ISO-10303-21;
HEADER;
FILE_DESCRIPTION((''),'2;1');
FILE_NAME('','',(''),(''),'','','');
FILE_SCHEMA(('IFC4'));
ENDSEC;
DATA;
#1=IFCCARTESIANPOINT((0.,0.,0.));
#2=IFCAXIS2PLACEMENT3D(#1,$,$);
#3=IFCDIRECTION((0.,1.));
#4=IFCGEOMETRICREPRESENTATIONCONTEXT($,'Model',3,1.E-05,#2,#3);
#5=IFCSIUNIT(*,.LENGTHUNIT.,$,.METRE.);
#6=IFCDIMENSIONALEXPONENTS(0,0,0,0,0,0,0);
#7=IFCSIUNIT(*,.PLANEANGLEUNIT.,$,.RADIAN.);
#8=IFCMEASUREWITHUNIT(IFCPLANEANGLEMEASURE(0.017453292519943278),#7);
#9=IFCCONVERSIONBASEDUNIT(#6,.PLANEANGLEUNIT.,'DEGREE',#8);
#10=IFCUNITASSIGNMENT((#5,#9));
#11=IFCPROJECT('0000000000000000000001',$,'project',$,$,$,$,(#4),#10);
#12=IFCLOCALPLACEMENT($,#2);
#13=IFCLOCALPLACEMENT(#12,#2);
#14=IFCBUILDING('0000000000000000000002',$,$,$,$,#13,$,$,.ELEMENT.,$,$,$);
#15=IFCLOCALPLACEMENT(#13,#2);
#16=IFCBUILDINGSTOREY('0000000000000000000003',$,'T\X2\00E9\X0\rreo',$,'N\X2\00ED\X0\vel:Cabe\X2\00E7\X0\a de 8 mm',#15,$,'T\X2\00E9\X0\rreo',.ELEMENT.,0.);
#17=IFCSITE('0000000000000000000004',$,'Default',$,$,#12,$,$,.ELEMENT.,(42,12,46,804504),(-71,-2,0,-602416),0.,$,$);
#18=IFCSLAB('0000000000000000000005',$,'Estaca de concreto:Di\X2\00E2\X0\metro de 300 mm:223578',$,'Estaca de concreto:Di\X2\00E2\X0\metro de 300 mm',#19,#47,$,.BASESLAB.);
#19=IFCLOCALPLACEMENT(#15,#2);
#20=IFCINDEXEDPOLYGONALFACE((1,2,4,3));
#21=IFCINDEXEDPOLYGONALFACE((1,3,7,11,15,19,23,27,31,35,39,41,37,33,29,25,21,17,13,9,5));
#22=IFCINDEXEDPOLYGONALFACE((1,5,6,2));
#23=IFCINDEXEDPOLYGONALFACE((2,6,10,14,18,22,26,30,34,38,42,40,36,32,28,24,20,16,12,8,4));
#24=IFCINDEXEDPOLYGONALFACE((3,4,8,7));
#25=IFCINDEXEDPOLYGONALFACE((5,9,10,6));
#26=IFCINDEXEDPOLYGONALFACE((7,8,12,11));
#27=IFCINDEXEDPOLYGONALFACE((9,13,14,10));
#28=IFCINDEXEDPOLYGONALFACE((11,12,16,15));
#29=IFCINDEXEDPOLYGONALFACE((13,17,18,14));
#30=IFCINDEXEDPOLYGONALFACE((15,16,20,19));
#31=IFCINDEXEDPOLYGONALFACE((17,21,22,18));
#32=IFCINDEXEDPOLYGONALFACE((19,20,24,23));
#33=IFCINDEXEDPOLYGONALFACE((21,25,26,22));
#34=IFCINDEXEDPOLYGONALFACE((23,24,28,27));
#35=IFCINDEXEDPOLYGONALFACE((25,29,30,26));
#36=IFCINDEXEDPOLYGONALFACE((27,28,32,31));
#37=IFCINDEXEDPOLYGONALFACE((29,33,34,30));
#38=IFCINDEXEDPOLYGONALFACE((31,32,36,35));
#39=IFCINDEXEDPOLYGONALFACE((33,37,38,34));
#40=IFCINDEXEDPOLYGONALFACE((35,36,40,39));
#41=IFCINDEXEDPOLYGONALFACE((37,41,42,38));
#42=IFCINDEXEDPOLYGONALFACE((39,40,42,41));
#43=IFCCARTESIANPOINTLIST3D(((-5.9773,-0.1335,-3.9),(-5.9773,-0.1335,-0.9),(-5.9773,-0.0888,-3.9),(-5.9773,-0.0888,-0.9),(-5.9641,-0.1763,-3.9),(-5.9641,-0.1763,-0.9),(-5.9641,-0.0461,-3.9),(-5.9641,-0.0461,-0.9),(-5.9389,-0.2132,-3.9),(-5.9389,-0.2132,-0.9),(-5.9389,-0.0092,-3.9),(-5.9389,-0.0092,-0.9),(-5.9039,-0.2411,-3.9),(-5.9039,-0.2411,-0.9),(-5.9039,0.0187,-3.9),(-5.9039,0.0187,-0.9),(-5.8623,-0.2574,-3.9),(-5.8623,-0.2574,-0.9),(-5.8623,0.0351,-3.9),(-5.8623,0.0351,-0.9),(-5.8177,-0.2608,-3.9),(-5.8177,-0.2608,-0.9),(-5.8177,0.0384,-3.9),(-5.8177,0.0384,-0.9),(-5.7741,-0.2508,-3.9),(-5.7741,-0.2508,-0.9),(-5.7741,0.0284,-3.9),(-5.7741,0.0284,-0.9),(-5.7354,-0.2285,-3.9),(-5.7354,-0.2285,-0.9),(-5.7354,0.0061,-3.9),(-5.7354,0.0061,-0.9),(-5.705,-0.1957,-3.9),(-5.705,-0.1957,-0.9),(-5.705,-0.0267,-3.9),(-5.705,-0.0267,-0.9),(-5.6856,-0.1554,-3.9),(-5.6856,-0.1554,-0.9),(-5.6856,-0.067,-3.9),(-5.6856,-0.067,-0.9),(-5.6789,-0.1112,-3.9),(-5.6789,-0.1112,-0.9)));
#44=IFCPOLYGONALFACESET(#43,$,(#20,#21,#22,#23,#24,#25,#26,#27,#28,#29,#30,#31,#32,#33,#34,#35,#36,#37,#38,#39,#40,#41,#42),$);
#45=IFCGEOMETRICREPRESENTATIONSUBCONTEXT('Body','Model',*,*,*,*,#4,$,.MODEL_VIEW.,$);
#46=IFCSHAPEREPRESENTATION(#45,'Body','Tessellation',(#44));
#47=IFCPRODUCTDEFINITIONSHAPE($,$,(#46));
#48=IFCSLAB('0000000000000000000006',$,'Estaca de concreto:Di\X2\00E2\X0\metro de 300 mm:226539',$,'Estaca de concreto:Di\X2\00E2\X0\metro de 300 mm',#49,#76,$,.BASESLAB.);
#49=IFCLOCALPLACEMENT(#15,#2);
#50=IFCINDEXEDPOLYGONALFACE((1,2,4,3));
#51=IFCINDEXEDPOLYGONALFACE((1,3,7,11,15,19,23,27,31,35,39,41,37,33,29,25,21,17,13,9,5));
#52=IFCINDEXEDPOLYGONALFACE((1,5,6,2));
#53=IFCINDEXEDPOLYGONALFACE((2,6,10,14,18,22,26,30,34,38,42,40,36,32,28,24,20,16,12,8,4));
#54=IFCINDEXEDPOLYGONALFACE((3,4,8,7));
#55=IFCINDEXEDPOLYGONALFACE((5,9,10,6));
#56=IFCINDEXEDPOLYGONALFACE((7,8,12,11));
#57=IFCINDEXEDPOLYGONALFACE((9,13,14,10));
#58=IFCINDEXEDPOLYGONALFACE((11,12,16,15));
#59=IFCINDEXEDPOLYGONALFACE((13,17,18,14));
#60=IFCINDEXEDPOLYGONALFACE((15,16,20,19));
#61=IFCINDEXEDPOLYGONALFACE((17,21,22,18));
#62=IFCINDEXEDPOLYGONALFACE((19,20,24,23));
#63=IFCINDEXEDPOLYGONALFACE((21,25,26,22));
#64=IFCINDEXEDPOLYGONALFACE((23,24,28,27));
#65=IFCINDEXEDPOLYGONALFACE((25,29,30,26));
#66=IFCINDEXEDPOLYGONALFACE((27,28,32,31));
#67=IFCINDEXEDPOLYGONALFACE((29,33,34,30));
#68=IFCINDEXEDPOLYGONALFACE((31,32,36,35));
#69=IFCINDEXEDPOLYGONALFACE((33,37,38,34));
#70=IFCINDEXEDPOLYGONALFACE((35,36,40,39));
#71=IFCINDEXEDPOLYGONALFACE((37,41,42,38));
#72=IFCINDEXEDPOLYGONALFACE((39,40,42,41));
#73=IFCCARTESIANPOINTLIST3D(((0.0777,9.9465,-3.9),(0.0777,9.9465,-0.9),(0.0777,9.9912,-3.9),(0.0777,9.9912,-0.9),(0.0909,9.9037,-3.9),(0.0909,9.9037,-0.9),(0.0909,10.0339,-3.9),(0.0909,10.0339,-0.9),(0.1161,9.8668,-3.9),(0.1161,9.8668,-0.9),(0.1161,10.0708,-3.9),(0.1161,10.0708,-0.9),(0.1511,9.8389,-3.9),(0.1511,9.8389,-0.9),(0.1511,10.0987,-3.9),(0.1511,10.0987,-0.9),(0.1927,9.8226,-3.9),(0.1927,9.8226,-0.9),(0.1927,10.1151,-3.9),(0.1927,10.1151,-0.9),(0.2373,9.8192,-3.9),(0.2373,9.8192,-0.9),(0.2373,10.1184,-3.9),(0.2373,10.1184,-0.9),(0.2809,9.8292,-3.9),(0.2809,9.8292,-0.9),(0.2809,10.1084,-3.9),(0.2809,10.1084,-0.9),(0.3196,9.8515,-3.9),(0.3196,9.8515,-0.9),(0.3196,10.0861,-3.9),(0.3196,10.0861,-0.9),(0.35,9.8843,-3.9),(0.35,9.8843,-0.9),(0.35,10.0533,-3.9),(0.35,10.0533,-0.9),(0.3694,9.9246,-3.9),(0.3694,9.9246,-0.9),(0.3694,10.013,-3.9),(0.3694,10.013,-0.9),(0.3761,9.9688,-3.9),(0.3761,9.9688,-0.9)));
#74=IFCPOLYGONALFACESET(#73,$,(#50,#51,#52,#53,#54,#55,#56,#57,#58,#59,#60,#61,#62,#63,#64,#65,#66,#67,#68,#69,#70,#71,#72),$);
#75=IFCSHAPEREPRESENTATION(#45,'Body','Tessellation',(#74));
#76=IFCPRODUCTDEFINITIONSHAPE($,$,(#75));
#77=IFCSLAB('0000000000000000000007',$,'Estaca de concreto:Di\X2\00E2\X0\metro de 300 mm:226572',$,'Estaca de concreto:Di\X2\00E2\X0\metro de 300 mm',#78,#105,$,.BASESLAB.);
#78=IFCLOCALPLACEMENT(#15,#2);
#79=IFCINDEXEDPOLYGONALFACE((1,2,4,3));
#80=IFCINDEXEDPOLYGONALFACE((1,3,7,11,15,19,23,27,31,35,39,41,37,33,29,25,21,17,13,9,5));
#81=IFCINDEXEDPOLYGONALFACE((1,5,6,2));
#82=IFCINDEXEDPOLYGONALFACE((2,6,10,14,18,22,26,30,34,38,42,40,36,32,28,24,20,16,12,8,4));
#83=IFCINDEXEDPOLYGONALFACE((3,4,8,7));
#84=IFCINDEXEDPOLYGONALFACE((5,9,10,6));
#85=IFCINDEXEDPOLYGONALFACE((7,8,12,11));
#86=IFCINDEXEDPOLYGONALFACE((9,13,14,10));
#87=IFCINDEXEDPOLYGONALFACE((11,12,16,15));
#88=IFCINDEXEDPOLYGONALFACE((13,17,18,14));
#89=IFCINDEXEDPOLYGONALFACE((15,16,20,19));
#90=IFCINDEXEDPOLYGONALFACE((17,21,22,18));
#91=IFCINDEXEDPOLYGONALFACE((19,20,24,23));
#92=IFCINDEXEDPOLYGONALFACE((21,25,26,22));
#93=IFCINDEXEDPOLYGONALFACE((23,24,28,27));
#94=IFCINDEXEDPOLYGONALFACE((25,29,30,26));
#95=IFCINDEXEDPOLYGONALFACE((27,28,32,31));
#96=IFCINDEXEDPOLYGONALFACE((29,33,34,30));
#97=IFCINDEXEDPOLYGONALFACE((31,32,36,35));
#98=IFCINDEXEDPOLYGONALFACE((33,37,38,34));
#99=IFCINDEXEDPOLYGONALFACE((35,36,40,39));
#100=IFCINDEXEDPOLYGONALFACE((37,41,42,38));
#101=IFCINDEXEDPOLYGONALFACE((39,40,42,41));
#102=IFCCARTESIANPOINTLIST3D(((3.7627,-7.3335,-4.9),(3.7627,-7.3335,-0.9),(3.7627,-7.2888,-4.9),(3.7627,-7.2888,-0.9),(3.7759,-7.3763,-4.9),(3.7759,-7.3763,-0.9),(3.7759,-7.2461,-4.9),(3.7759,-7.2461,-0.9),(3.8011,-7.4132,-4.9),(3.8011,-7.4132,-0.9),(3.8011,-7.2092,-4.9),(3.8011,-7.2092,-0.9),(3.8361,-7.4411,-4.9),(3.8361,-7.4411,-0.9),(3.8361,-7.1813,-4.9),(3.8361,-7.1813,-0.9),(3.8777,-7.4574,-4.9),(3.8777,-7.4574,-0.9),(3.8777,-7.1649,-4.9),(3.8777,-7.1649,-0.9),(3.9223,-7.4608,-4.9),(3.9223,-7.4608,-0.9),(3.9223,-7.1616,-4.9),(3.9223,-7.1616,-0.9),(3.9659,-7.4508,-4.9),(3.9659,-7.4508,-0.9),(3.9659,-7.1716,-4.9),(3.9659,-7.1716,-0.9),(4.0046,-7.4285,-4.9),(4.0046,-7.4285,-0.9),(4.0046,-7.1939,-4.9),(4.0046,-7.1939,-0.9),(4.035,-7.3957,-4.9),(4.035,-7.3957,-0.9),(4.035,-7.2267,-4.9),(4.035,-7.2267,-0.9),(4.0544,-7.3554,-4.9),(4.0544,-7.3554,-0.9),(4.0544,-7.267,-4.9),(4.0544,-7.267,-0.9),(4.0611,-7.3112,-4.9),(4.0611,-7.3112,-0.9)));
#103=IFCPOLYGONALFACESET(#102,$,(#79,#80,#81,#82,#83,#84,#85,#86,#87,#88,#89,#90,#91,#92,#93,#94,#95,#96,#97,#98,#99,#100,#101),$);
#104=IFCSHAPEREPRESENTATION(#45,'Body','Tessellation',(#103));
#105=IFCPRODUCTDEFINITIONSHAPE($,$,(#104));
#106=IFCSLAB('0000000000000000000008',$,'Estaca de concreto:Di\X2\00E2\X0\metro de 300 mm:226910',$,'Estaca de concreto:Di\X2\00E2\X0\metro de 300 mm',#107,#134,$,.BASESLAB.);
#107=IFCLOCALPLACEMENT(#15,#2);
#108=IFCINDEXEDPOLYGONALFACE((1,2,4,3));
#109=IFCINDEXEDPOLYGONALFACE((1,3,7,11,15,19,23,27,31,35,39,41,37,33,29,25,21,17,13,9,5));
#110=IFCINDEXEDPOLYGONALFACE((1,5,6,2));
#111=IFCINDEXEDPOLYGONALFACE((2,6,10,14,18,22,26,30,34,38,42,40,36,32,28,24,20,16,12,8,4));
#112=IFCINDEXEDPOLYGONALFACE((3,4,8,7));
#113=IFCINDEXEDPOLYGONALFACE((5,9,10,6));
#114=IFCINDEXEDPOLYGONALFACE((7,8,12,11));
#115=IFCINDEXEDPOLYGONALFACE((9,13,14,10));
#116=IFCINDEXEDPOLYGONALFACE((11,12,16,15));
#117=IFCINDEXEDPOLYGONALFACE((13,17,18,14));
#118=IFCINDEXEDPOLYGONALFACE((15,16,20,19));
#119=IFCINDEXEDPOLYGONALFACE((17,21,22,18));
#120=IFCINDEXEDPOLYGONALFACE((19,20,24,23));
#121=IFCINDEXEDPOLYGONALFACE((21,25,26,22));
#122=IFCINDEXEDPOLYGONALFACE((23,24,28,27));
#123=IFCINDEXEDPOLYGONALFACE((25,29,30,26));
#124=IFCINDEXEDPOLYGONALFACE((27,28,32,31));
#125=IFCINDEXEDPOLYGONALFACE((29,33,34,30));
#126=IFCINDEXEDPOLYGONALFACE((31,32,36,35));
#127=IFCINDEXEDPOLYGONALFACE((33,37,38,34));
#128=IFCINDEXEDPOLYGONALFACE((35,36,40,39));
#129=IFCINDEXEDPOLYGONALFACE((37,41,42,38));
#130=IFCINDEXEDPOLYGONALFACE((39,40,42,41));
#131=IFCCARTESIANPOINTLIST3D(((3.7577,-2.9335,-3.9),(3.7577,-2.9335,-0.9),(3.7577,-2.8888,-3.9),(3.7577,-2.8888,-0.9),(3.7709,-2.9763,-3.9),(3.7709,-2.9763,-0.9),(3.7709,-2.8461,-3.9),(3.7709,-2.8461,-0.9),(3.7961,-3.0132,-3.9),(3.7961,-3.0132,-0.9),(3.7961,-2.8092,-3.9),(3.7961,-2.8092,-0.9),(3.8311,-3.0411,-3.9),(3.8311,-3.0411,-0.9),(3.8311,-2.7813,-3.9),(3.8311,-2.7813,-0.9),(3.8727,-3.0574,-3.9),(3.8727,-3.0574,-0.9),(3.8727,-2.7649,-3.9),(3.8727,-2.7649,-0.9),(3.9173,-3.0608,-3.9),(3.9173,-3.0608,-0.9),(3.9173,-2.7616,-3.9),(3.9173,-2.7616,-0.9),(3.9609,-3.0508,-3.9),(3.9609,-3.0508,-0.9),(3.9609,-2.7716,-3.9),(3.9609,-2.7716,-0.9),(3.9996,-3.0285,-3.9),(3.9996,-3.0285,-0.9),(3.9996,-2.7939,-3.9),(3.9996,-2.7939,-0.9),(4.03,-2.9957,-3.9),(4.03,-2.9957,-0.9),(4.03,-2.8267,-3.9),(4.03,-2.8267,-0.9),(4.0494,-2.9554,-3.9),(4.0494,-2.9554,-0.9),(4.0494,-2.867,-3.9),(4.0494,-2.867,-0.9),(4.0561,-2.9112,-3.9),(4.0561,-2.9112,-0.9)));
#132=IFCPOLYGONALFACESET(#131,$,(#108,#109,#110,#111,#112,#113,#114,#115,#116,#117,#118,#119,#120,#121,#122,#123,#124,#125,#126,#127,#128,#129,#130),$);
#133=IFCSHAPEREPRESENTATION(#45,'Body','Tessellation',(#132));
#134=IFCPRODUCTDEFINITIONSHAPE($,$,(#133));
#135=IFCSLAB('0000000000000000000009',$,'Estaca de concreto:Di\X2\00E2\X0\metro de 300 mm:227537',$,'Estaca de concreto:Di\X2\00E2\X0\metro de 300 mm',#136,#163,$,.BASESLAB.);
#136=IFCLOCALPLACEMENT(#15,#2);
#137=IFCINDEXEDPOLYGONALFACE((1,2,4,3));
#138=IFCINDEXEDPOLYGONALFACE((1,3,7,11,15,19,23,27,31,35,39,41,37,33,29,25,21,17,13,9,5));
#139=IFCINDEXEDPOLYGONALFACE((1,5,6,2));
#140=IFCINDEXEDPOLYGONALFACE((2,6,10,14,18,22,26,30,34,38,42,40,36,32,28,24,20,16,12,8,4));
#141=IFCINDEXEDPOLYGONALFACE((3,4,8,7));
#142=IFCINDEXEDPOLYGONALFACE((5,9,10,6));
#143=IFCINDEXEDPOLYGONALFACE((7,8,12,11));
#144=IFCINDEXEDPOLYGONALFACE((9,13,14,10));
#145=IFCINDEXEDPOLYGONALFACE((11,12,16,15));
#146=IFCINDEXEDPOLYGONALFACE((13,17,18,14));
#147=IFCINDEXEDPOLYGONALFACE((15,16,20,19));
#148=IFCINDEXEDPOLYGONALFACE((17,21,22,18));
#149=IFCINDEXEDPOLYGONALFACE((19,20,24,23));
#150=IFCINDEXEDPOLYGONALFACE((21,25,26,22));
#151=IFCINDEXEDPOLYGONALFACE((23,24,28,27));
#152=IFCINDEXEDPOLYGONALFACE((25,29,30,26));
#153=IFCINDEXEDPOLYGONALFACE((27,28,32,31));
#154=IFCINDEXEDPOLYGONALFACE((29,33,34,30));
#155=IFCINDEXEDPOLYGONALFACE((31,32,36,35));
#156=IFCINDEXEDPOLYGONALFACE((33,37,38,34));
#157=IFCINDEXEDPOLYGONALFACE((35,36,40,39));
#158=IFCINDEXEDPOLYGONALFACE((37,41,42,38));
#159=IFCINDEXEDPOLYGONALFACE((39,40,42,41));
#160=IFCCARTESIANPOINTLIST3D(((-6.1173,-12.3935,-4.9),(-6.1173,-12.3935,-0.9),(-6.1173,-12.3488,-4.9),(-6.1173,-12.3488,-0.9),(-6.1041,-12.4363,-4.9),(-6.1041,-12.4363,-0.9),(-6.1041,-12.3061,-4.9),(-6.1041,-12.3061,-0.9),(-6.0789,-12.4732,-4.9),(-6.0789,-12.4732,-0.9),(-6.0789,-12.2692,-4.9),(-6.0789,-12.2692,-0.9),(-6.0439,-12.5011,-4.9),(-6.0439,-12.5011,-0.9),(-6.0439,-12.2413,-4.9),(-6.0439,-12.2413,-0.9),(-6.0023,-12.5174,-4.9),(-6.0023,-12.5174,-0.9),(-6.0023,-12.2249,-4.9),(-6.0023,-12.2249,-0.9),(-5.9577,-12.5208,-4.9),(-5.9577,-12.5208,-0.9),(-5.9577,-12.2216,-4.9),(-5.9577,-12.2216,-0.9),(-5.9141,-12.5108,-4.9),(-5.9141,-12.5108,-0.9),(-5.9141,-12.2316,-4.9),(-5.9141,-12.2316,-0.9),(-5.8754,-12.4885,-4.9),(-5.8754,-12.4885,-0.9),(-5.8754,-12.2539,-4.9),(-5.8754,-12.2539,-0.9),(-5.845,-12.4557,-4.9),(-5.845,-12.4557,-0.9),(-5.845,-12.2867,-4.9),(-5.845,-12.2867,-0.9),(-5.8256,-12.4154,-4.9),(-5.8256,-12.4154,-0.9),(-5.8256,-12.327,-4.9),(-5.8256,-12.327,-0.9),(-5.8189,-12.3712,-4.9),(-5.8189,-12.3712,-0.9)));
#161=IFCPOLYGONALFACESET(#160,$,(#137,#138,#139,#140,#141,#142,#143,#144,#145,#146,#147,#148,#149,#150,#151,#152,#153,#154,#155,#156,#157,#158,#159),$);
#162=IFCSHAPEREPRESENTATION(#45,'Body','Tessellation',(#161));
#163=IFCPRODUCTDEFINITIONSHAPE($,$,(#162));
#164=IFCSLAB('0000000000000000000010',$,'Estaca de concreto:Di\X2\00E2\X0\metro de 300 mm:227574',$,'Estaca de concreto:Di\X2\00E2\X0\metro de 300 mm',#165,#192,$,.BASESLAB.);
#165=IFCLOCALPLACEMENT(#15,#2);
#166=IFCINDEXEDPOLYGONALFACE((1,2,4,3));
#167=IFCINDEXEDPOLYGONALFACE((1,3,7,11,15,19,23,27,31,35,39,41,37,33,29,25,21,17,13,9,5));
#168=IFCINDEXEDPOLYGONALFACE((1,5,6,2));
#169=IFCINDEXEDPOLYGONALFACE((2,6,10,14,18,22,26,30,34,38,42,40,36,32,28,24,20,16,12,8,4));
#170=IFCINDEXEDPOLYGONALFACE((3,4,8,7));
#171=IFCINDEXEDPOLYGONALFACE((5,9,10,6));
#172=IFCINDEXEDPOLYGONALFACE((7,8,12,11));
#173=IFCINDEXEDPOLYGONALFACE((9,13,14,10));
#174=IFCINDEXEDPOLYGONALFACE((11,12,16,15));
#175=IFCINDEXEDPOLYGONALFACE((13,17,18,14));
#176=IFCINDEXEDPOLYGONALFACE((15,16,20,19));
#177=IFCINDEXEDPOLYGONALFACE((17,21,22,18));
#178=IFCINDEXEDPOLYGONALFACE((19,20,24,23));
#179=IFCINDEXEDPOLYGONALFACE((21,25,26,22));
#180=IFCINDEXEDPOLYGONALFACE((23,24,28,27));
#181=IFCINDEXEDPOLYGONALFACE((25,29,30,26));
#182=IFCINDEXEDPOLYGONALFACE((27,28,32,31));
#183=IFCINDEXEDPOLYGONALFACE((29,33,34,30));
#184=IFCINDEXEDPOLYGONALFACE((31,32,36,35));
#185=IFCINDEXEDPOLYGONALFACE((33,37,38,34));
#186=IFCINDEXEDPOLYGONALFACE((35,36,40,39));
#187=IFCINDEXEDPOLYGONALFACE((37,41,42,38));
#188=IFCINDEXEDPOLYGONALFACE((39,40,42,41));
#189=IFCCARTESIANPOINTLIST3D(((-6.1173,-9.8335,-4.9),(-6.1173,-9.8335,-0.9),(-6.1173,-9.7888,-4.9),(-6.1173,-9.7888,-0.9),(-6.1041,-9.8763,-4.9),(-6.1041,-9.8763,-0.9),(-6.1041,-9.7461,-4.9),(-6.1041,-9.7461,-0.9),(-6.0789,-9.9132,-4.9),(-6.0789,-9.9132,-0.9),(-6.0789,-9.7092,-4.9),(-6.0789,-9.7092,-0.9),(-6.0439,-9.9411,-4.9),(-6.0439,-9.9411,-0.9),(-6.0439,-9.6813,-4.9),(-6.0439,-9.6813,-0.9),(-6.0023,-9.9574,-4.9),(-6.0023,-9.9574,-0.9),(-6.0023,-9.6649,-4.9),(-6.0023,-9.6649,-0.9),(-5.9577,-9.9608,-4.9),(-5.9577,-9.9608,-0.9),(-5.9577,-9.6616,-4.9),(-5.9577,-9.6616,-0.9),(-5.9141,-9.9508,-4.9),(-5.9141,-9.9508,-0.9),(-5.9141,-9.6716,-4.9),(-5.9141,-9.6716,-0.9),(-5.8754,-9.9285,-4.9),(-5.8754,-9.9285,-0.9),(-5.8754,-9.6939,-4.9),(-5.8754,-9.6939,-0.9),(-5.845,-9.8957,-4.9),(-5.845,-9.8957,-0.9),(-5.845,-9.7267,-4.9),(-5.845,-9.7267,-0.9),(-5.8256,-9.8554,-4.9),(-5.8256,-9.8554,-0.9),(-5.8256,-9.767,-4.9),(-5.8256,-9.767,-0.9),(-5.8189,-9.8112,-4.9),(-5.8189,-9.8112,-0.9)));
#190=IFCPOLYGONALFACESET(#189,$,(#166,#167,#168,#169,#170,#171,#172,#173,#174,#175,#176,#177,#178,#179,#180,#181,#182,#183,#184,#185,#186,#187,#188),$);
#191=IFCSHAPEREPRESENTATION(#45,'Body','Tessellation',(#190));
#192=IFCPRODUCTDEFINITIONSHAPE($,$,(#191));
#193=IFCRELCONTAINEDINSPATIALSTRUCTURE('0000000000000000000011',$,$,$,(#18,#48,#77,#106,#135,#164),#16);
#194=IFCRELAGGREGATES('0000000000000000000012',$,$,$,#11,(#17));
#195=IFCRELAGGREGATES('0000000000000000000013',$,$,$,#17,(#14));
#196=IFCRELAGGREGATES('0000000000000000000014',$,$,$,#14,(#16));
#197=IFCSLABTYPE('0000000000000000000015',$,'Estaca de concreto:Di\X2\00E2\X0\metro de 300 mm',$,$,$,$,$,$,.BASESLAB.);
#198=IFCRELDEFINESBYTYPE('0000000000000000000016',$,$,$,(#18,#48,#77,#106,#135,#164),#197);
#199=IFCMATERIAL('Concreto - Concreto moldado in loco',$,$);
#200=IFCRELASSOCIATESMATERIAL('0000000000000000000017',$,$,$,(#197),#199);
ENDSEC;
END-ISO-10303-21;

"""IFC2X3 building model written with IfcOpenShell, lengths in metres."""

from ifc_helpers import new_model, entity, si_unit, converted_unit, direction, frame, frame_2d, origin, origin_2d_with_axis, place, context, subcontext, project, spatial, circle, extrude, material, type_object, element, save


model = new_model("IFC2X3")

# Units and contexts
model_context = context("Model", 3, precision=1e-05, world=origin(), true_north=direction((0.0, 1.0)))
body_context = subcontext(model_context, "Body", "Model", "MODEL_VIEW")
ifc_project = project(units=[si_unit("LENGTHUNIT", "METRE"), converted_unit("PLANEANGLEUNIT", "DEGREE", entity("IfcPlaneAngleMeasure", 0.017453292519943278), si_unit("PLANEANGLEUNIT", "RADIAN"), dimensions=[0, 0, 0, 0, 0, 0, 0])], contexts=[model_context])

# Site, building, storey
site_placement = place(None, origin())
site = spatial("IfcSite", under=ifc_project, at=site_placement, Name="Default", CompositionType="ELEMENT", RefLatitude=(42, 12, 46, 804504), RefLongitude=(-71, -2, 0, -602416), RefElevation=0.0)
building_placement = place(site_placement, origin())
building = spatial("IfcBuilding", under=site, at=building_placement, CompositionType="ELEMENT")
storey_placement = place(building_placement, origin())
storey = spatial("IfcBuildingStorey", under=building, at=storey_placement, Name="Térreo", ObjectType="Nível:Cabeça de 8 mm", LongName="Térreo", CompositionType="ELEMENT", Elevation=0.0)

# Slabs
ifc_material_1 = material(Name="Concreto - Concreto moldado in loco")
slab_type_1 = type_object("IfcSlabType", Name="Estaca de concreto:Diâmetro de 300 mm", PredefinedType="BASESLAB", material=ifc_material_1)
slab_1_placement = place(storey_placement, origin())
element("IfcSlab", 1, at=slab_1_placement, inside=storey, type_object=slab_type_1, Name="Estaca de concreto:Diâmetro de 300 mm:223578", ObjectType="Estaca de concreto:Diâmetro de 300 mm", PredefinedType="BASESLAB", context=body_context, shape_type="SweptSolid", body=[
    extrude(circle(Radius=0.15, at=frame_2d((0.0, 0.0), x_axis=(1.0, 0.0))), frame((-5.8289, -0.1112, -3.9)), (0.0, 0.0, 1.0), 3.0),
])
slab_2_placement = place(storey_placement, origin())
element("IfcSlab", 2, at=slab_2_placement, inside=storey, type_object=slab_type_1, Name="Estaca de concreto:Diâmetro de 300 mm:226539", ObjectType="Estaca de concreto:Diâmetro de 300 mm", PredefinedType="BASESLAB", context=body_context, shape_type="SweptSolid", body=[
    extrude(circle(Radius=0.15, at=origin_2d_with_axis()), frame((0.2261, 9.9688, -3.9)), (0.0, 0.0, 1.0), 3.0),
])
slab_3_placement = place(storey_placement, origin())
element("IfcSlab", 3, at=slab_3_placement, inside=storey, type_object=slab_type_1, Name="Estaca de concreto:Diâmetro de 300 mm:226572", ObjectType="Estaca de concreto:Diâmetro de 300 mm", PredefinedType="BASESLAB", context=body_context, shape_type="SweptSolid", body=[
    extrude(circle(Radius=0.15, at=origin_2d_with_axis()), frame((3.9111, -7.3112, -4.9)), (0.0, 0.0, 1.0), 4.0),
])
slab_4_placement = place(storey_placement, origin())
element("IfcSlab", 4, at=slab_4_placement, inside=storey, type_object=slab_type_1, Name="Estaca de concreto:Diâmetro de 300 mm:226910", ObjectType="Estaca de concreto:Diâmetro de 300 mm", PredefinedType="BASESLAB", context=body_context, shape_type="SweptSolid", body=[
    extrude(circle(Radius=0.15, at=frame_2d((0.0, 0.0), x_axis=(1.0, 0.0))), frame((3.9061, -2.9112, -3.9)), (0.0, 0.0, 1.0), 3.0),
])
slab_5_placement = place(storey_placement, origin())
element("IfcSlab", 5, at=slab_5_placement, inside=storey, type_object=slab_type_1, Name="Estaca de concreto:Diâmetro de 300 mm:227537", ObjectType="Estaca de concreto:Diâmetro de 300 mm", PredefinedType="BASESLAB", context=body_context, shape_type="SweptSolid", body=[
    extrude(circle(Radius=0.15, at=origin_2d_with_axis()), frame((-5.9689, -12.3712, -4.9)), (0.0, 0.0, 1.0), 4.0),
])
slab_6_placement = place(storey_placement, origin())
element("IfcSlab", 6, at=slab_6_placement, inside=storey, type_object=slab_type_1, Name="Estaca de concreto:Diâmetro de 300 mm:227574", ObjectType="Estaca de concreto:Diâmetro de 300 mm", PredefinedType="BASESLAB", context=body_context, shape_type="SweptSolid", body=[
    extrude(circle(Radius=0.15, at=origin_2d_with_axis()), frame((-5.9689, -9.8112, -4.9)), (0.0, 0.0, 1.0), 4.0),
])

save(model, "model.ifc")
